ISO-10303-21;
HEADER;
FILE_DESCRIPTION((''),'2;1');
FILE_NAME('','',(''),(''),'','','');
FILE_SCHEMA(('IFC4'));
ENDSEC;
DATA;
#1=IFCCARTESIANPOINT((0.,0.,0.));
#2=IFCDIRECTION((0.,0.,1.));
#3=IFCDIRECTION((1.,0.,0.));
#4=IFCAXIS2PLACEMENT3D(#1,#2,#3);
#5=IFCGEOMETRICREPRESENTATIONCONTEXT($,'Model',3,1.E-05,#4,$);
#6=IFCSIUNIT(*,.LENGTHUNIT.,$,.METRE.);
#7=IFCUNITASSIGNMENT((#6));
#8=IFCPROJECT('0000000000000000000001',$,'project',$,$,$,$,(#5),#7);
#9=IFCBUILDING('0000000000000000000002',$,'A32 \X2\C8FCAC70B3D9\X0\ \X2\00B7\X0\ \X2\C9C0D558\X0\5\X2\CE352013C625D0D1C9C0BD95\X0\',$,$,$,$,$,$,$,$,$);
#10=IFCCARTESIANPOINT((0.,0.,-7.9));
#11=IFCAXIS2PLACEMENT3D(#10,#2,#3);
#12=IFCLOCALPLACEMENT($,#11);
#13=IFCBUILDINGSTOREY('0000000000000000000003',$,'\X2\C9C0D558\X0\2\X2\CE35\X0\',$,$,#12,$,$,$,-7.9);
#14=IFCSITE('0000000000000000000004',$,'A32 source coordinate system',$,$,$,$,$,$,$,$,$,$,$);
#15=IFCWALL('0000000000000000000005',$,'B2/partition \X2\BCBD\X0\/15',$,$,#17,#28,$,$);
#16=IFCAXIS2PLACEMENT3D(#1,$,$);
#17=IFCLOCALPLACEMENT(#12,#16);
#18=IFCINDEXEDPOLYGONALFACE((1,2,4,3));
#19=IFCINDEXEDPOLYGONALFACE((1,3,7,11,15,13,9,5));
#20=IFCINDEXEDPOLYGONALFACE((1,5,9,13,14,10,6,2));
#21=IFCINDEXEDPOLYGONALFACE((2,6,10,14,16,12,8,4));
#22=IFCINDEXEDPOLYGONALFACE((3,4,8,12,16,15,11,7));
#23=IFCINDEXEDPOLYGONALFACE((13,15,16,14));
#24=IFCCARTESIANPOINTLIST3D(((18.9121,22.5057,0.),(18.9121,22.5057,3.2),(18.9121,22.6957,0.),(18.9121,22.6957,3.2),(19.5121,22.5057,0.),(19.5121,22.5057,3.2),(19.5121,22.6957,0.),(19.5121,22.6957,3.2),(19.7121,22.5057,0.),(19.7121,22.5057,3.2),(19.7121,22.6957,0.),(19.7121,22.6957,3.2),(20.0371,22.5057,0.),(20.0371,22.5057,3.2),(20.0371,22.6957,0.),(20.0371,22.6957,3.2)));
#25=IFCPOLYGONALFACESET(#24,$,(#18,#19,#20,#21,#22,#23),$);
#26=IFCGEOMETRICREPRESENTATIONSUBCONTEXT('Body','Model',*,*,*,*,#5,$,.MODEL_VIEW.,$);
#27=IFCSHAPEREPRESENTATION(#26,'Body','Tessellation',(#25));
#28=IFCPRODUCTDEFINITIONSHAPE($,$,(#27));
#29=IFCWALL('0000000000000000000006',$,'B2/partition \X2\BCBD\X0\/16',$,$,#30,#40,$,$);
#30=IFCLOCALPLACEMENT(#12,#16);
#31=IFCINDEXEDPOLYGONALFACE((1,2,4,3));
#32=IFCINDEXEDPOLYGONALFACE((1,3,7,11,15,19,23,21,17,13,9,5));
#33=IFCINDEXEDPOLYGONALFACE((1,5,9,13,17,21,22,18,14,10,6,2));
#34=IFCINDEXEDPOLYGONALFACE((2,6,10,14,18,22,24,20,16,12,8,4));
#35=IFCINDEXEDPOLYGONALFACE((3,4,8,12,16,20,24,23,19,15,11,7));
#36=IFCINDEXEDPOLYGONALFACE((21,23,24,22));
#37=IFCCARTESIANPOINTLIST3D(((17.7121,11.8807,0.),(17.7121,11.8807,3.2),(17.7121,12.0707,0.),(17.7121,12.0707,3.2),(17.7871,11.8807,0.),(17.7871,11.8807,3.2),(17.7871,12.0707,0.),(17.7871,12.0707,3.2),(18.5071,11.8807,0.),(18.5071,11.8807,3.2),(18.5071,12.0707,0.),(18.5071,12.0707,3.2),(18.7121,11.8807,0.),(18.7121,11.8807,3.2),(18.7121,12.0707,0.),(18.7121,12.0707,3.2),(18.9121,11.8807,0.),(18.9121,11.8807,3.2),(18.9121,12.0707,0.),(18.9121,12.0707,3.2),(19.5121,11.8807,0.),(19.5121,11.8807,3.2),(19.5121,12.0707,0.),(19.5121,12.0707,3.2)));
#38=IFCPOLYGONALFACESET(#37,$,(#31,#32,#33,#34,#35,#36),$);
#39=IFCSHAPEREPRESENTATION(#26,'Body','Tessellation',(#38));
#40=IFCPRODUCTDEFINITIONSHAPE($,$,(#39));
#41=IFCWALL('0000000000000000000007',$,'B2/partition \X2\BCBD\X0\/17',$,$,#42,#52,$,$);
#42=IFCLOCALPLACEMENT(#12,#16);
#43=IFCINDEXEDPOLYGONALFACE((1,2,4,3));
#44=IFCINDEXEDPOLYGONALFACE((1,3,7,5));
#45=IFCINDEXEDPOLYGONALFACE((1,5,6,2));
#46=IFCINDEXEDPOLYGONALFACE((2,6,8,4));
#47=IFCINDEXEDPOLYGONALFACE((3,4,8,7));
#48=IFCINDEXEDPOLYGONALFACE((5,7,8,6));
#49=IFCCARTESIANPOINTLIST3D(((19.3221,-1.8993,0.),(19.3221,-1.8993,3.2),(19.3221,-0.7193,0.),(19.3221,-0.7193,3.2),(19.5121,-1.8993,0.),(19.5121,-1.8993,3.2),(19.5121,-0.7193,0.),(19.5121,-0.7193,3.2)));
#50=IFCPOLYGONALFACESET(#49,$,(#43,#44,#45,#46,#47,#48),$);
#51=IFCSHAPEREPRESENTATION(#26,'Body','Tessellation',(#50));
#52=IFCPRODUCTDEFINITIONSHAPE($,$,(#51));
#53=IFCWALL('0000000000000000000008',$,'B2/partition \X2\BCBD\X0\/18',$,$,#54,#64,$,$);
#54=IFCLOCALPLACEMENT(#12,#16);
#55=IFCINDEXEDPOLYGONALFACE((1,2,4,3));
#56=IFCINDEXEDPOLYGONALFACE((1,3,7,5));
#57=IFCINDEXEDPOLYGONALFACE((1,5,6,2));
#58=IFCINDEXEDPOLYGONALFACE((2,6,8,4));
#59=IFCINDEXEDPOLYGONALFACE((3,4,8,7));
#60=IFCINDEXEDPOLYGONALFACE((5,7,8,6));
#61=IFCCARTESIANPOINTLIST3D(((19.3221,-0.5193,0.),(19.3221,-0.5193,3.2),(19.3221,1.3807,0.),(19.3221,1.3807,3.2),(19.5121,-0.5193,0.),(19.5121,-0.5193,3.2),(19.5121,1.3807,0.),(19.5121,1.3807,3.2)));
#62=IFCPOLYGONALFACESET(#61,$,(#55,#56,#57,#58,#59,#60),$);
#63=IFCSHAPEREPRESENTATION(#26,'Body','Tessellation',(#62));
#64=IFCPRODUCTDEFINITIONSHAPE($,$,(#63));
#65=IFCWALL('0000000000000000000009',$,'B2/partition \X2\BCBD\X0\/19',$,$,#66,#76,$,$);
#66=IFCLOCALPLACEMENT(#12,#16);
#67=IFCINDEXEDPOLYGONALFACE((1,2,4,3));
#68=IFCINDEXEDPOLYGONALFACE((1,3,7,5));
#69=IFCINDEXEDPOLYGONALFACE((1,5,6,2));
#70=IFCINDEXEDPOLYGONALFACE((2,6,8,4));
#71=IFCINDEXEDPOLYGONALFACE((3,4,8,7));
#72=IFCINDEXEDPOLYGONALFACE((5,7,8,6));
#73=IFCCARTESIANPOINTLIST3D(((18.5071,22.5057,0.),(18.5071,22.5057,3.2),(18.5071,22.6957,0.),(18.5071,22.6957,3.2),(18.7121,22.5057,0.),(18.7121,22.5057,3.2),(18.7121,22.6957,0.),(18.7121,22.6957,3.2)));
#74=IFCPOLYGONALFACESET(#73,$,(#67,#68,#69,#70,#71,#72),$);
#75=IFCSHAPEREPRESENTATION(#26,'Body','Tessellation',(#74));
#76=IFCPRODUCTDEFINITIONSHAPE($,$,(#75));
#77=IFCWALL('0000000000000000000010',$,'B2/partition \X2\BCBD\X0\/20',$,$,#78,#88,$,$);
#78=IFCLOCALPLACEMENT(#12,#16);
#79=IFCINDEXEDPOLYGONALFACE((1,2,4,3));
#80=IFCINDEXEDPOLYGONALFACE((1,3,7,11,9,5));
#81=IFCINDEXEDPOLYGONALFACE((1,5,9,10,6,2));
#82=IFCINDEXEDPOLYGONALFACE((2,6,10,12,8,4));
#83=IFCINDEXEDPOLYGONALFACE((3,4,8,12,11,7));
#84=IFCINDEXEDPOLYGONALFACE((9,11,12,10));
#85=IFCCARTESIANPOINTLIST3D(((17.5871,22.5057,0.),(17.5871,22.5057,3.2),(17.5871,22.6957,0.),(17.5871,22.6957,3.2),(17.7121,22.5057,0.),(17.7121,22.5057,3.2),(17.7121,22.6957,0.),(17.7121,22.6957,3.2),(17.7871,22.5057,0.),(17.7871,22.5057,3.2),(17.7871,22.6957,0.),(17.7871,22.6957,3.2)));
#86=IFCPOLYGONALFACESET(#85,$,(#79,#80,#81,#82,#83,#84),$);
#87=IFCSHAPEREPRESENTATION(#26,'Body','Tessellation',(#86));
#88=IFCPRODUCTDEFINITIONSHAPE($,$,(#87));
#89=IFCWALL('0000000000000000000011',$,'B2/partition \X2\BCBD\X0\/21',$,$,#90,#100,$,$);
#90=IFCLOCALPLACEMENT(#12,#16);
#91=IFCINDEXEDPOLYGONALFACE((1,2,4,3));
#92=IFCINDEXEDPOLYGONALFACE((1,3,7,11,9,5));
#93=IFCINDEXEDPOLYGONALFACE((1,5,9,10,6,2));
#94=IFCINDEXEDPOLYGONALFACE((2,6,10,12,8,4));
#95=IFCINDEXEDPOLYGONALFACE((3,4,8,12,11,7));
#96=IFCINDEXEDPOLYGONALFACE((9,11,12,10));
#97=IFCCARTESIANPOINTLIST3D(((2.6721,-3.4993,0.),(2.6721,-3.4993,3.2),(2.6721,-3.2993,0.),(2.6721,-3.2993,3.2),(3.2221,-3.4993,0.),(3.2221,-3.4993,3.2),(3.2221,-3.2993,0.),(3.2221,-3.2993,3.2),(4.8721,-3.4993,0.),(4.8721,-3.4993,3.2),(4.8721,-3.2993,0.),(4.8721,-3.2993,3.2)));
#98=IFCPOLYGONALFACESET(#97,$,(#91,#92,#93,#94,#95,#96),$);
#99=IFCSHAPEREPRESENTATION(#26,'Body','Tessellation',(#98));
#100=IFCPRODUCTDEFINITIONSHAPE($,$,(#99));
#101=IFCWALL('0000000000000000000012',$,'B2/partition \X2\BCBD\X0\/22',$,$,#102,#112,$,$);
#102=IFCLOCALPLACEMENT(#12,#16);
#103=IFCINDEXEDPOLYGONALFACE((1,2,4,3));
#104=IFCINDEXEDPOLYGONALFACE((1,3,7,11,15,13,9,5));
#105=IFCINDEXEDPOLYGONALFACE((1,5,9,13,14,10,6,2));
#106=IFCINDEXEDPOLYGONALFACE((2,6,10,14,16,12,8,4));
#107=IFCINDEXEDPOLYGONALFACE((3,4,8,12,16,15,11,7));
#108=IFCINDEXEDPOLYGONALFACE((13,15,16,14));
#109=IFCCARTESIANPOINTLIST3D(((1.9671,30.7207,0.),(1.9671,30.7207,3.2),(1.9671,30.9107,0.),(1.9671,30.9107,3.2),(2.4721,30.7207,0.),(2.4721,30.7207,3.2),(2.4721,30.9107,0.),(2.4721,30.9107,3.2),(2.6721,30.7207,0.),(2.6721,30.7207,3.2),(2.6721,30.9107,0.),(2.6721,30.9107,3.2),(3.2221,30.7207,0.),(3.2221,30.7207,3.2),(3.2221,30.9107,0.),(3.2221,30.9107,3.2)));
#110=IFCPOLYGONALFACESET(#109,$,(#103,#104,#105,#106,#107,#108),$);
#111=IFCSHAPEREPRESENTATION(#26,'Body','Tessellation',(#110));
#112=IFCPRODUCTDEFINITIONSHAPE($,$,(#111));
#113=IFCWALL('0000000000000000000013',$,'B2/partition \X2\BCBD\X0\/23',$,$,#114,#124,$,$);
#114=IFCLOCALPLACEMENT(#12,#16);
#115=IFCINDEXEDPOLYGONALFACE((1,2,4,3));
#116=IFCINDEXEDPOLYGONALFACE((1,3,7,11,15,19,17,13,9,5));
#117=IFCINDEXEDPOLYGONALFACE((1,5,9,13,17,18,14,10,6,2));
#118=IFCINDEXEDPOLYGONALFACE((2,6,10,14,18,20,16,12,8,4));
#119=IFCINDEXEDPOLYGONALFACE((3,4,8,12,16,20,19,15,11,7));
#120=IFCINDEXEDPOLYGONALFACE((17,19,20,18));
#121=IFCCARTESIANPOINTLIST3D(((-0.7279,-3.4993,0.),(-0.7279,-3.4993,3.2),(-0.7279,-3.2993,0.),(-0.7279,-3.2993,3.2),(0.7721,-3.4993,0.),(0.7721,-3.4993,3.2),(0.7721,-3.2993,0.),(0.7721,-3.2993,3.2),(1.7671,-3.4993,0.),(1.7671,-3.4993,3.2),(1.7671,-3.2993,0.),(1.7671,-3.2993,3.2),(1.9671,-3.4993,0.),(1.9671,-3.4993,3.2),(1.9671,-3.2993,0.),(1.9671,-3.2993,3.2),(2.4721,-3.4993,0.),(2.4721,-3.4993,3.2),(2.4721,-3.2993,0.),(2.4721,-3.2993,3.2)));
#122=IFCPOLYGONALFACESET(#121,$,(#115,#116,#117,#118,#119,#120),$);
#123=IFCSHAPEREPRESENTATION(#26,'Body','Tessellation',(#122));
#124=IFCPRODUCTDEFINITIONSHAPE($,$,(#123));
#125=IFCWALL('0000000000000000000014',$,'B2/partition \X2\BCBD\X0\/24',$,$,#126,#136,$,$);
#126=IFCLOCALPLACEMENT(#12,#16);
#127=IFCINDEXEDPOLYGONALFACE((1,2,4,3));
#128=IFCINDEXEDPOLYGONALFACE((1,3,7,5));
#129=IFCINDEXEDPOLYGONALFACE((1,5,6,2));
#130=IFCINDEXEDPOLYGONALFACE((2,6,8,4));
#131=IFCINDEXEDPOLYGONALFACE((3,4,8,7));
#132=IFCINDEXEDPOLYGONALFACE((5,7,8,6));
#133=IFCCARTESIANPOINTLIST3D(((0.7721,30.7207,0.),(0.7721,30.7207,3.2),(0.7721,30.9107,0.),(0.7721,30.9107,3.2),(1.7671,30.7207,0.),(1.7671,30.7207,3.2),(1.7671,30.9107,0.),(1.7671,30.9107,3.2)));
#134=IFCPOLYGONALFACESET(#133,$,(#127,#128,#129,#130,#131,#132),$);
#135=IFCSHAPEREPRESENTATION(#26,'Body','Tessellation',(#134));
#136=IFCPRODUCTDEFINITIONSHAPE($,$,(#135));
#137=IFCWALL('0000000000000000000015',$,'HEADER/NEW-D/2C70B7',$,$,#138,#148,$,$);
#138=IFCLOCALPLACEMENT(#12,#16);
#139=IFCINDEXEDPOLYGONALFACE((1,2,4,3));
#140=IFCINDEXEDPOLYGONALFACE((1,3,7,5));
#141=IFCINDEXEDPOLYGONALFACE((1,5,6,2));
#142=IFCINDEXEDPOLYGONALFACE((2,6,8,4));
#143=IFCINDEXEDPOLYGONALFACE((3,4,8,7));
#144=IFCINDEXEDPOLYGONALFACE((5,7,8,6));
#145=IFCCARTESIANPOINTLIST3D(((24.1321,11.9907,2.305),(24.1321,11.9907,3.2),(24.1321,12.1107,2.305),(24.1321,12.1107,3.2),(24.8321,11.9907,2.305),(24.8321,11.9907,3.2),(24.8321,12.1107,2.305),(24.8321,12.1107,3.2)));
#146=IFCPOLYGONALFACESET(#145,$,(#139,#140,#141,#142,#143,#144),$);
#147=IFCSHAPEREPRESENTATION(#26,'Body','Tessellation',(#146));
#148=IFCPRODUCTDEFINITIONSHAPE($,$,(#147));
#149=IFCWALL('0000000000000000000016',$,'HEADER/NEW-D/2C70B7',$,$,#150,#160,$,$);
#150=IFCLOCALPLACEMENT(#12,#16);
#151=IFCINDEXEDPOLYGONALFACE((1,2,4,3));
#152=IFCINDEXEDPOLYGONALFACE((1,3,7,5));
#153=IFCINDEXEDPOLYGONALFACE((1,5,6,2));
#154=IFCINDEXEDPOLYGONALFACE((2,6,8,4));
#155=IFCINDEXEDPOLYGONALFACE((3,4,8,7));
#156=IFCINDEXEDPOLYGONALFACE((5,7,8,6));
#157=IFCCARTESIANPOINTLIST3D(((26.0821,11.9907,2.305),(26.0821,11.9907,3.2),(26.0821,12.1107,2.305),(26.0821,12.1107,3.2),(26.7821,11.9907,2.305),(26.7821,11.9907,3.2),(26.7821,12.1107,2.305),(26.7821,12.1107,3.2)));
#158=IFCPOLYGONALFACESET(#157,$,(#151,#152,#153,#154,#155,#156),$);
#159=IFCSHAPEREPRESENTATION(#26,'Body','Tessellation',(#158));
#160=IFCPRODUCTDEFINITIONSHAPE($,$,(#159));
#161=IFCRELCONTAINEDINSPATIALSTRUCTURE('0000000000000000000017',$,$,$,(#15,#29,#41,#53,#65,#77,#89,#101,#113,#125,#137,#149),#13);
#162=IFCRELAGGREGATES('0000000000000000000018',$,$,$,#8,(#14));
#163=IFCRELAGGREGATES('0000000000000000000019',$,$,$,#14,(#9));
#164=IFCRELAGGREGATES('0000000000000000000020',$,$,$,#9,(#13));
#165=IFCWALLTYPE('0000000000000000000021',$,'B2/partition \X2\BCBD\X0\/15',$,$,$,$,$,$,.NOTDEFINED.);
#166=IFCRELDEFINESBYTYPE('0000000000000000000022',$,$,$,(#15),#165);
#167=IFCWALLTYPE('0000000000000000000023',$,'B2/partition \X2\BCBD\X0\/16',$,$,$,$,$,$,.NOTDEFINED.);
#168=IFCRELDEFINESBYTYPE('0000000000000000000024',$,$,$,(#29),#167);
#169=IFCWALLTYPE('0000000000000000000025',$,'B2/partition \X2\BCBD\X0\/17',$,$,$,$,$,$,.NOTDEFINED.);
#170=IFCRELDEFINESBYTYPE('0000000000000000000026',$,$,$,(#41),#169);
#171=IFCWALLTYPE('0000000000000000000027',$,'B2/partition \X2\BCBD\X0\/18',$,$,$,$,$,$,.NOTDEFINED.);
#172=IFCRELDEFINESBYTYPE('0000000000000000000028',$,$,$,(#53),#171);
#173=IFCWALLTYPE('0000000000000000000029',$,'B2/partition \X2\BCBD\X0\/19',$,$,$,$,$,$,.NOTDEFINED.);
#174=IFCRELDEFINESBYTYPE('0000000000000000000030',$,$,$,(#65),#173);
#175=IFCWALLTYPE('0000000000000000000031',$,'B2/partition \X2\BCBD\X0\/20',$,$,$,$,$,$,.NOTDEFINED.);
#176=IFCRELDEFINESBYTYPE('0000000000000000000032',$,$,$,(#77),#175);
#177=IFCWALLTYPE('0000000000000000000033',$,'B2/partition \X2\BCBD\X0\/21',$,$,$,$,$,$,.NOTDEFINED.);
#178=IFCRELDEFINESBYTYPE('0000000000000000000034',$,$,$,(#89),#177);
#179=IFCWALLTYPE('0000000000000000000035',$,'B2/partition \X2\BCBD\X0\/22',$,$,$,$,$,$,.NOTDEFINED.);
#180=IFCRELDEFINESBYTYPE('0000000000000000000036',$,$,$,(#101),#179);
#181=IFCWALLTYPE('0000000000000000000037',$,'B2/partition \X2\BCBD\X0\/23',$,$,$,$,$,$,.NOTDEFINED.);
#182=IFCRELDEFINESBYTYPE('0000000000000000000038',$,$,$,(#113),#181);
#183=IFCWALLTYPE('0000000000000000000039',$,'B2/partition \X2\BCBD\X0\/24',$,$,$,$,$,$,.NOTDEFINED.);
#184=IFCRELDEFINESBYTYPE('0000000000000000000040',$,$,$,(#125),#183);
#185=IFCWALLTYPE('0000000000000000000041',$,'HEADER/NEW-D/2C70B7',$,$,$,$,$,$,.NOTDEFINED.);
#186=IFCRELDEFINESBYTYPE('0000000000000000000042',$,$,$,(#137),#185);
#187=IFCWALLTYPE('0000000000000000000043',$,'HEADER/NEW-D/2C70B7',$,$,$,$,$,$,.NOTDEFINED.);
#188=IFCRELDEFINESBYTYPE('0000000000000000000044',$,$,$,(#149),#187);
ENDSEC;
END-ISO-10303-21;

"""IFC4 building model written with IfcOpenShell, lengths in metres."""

from ifc_helpers import new_model, si_unit, frame, origin, origin_with_axes, place, context, subcontext, project, spatial, polyline, outline, extrude, source, transform, mapped, type_object, type_shapes, element, save


model = new_model("IFC4")

# Units and contexts
model_context = context("Model", 3, precision=1e-05, world=origin_with_axes())
body_context = subcontext(model_context, "Body", "Model", "MODEL_VIEW")
ifc_project = project(units=[si_unit("LENGTHUNIT", "METRE")], contexts=[model_context])

# Site, building, storey
site = spatial("IfcSite", under=ifc_project, Name="A32 source coordinate system")
building = spatial("IfcBuilding", under=site, Name="A32 주거동 · 지하5층–옥탑지붕")
storey_placement = place(None, frame((0.0, 0.0, -7.9), z_axis=(0.0, 0.0, 1.0), x_axis=(1.0, 0.0, 0.0)))
storey = spatial("IfcBuildingStorey", under=building, at=storey_placement, Name="지하2층", Elevation=-7.9)

# Walls
wall_type_1 = type_object("IfcWallType", Name="B2/partition 벽/15", PredefinedType="NOTDEFINED")
shared_shape_1 = source(origin(), body_context, "Body", "SweptSolid", [
    extrude(outline(polyline([(19.7121, 22.5057), (19.5121, 22.5057), (18.9121, 22.5057), (18.9121, 22.6957), (19.5121, 22.6957), (19.7121, 22.6957), (20.0371, 22.6957), (20.0371, 22.5057), (19.7121, 22.5057)])), origin(), (0.0, 0.0, 1.0), 3.2),
])
type_shapes(wall_type_1, [shared_shape_1])
wall_1_placement = place(storey_placement, origin_with_axes())
element("IfcWall", 1, at=wall_1_placement, inside=storey, type_object=wall_type_1, Name="B2/partition 벽/15", context=body_context, shape_type="MappedRepresentation", body=[
    mapped(shared_shape_1, transform((0.0, 0.0, 0.0), scale=1.0)),
])
wall_type_2 = type_object("IfcWallType", Name="B2/partition 벽/16", PredefinedType="NOTDEFINED")
shared_shape_2 = source(origin(), body_context, "Body", "SweptSolid", [
    extrude(outline(polyline([(18.9121, 12.0707), (19.5121, 12.0707), (19.5121, 11.8807), (18.9121, 11.8807), (18.7121, 11.8807), (18.5071, 11.8807), (17.7871, 11.8807), (17.7121, 11.8807), (17.7121, 12.0707), (17.7871, 12.0707), (18.5071, 12.0707), (18.7121, 12.0707), (18.9121, 12.0707)])), origin(), (0.0, 0.0, 1.0), 3.2),
])
type_shapes(wall_type_2, [shared_shape_2])
wall_2_placement = place(storey_placement, origin_with_axes())
element("IfcWall", 2, at=wall_2_placement, inside=storey, type_object=wall_type_2, Name="B2/partition 벽/16", context=body_context, shape_type="MappedRepresentation", body=[
    mapped(shared_shape_2, transform((0.0, 0.0, 0.0), scale=1.0)),
])
wall_type_3 = type_object("IfcWallType", Name="B2/partition 벽/17", PredefinedType="NOTDEFINED")
shared_shape_3 = source(origin(), body_context, "Body", "SweptSolid", [
    extrude(outline(polyline([(19.5121, -0.7193), (19.5121, -1.8993), (19.3221, -1.8993), (19.3221, -0.7193), (19.5121, -0.7193)])), origin(), (0.0, 0.0, 1.0), 3.2),
])
type_shapes(wall_type_3, [shared_shape_3])
wall_3_placement = place(storey_placement, origin_with_axes())
element("IfcWall", 3, at=wall_3_placement, inside=storey, type_object=wall_type_3, Name="B2/partition 벽/17", context=body_context, shape_type="MappedRepresentation", body=[
    mapped(shared_shape_3, transform((0.0, 0.0, 0.0), scale=1.0)),
])
wall_type_4 = type_object("IfcWallType", Name="B2/partition 벽/18", PredefinedType="NOTDEFINED")
shared_shape_4 = source(origin(), body_context, "Body", "SweptSolid", [
    extrude(outline(polyline([(19.3221, 1.3807), (19.5121, 1.3807), (19.5121, -0.5193), (19.3221, -0.5193), (19.3221, 1.3807)])), origin(), (0.0, 0.0, 1.0), 3.2),
])
type_shapes(wall_type_4, [shared_shape_4])
wall_4_placement = place(storey_placement, origin_with_axes())
element("IfcWall", 4, at=wall_4_placement, inside=storey, type_object=wall_type_4, Name="B2/partition 벽/18", context=body_context, shape_type="MappedRepresentation", body=[
    mapped(shared_shape_4, transform((0.0, 0.0, 0.0), scale=1.0)),
])
wall_type_5 = type_object("IfcWallType", Name="B2/partition 벽/19", PredefinedType="NOTDEFINED")
shared_shape_5 = source(origin(), body_context, "Body", "SweptSolid", [
    extrude(outline(polyline([(18.5071, 22.6957), (18.7121, 22.6957), (18.7121, 22.5057), (18.5071, 22.5057), (18.5071, 22.6957)])), origin(), (0.0, 0.0, 1.0), 3.2),
])
type_shapes(wall_type_5, [shared_shape_5])
wall_5_placement = place(storey_placement, origin_with_axes())
element("IfcWall", 5, at=wall_5_placement, inside=storey, type_object=wall_type_5, Name="B2/partition 벽/19", context=body_context, shape_type="MappedRepresentation", body=[
    mapped(shared_shape_5, transform((0.0, 0.0, 0.0), scale=1.0)),
])
wall_type_6 = type_object("IfcWallType", Name="B2/partition 벽/20", PredefinedType="NOTDEFINED")
shared_shape_6 = source(origin(), body_context, "Body", "SweptSolid", [
    extrude(outline(polyline([(17.5871, 22.5057), (17.5871, 22.6957), (17.7121, 22.6957), (17.7871, 22.6957), (17.7871, 22.5057), (17.7121, 22.5057), (17.5871, 22.5057)])), origin(), (0.0, 0.0, 1.0), 3.2),
])
type_shapes(wall_type_6, [shared_shape_6])
wall_6_placement = place(storey_placement, origin_with_axes())
element("IfcWall", 6, at=wall_6_placement, inside=storey, type_object=wall_type_6, Name="B2/partition 벽/20", context=body_context, shape_type="MappedRepresentation", body=[
    mapped(shared_shape_6, transform((0.0, 0.0, 0.0), scale=1.0)),
])
wall_type_7 = type_object("IfcWallType", Name="B2/partition 벽/21", PredefinedType="NOTDEFINED")
shared_shape_7 = source(origin(), body_context, "Body", "SweptSolid", [
    extrude(outline(polyline([(2.6721, -3.4993), (2.6721, -3.2993), (3.2221, -3.2993), (4.8721, -3.2993), (4.8721, -3.4993), (3.2221, -3.4993), (2.6721, -3.4993)])), origin(), (0.0, 0.0, 1.0), 3.2),
])
type_shapes(wall_type_7, [shared_shape_7])
wall_7_placement = place(storey_placement, origin_with_axes())
element("IfcWall", 7, at=wall_7_placement, inside=storey, type_object=wall_type_7, Name="B2/partition 벽/21", context=body_context, shape_type="MappedRepresentation", body=[
    mapped(shared_shape_7, transform((0.0, 0.0, 0.0), scale=1.0)),
])
wall_type_8 = type_object("IfcWallType", Name="B2/partition 벽/22", PredefinedType="NOTDEFINED")
shared_shape_8 = source(origin(), body_context, "Body", "SweptSolid", [
    extrude(outline(polyline([(2.6721, 30.7207), (2.4721, 30.7207), (1.9671, 30.7207), (1.9671, 30.9107), (2.4721, 30.9107), (2.6721, 30.9107), (3.2221, 30.9107), (3.2221, 30.7207), (2.6721, 30.7207)])), origin(), (0.0, 0.0, 1.0), 3.2),
])
type_shapes(wall_type_8, [shared_shape_8])
wall_8_placement = place(storey_placement, origin_with_axes())
element("IfcWall", 8, at=wall_8_placement, inside=storey, type_object=wall_type_8, Name="B2/partition 벽/22", context=body_context, shape_type="MappedRepresentation", body=[
    mapped(shared_shape_8, transform((0.0, 0.0, 0.0), scale=1.0)),
])
wall_type_9 = type_object("IfcWallType", Name="B2/partition 벽/23", PredefinedType="NOTDEFINED")
shared_shape_9 = source(origin(), body_context, "Body", "SweptSolid", [
    extrude(outline(polyline([(2.4721, -3.2993), (2.4721, -3.4993), (1.9671, -3.4993), (1.7671, -3.4993), (0.7721, -3.4993), (-0.7279, -3.4993), (-0.7279, -3.2993), (0.7721, -3.2993), (1.7671, -3.2993), (1.9671, -3.2993), (2.4721, -3.2993)])), origin(), (0.0, 0.0, 1.0), 3.2),
])
type_shapes(wall_type_9, [shared_shape_9])
wall_9_placement = place(storey_placement, origin_with_axes())
element("IfcWall", 9, at=wall_9_placement, inside=storey, type_object=wall_type_9, Name="B2/partition 벽/23", context=body_context, shape_type="MappedRepresentation", body=[
    mapped(shared_shape_9, transform((0.0, 0.0, 0.0), scale=1.0)),
])
wall_type_10 = type_object("IfcWallType", Name="B2/partition 벽/24", PredefinedType="NOTDEFINED")
shared_shape_10 = source(origin(), body_context, "Body", "SweptSolid", [
    extrude(outline(polyline([(1.7671, 30.9107), (1.7671, 30.7207), (0.7721, 30.7207), (0.7721, 30.9107), (1.7671, 30.9107)])), origin(), (0.0, 0.0, 1.0), 3.2),
])
type_shapes(wall_type_10, [shared_shape_10])
wall_10_placement = place(storey_placement, origin_with_axes())
element("IfcWall", 10, at=wall_10_placement, inside=storey, type_object=wall_type_10, Name="B2/partition 벽/24", context=body_context, shape_type="MappedRepresentation", body=[
    mapped(shared_shape_10, transform((0.0, 0.0, 0.0), scale=1.0)),
])
wall_type_11 = type_object("IfcWallType", Name="HEADER/NEW-D/2C70B7", PredefinedType="NOTDEFINED")
shared_shape_11 = source(origin(), body_context, "Body", "SweptSolid", [
    extrude(outline(polyline([(24.1321, 11.9907), (24.1321, 12.1107), (24.8321, 12.1107), (24.8321, 11.9907), (24.1321, 11.9907)])), frame((0.0, 0.0, 2.305)), (0.0, 0.0, 1.0), 0.895),
])
type_shapes(wall_type_11, [shared_shape_11])
wall_11_placement = place(storey_placement, origin_with_axes())
element("IfcWall", 11, at=wall_11_placement, inside=storey, type_object=wall_type_11, Name="HEADER/NEW-D/2C70B7", context=body_context, shape_type="MappedRepresentation", body=[
    mapped(shared_shape_11, transform((0.0, 0.0, 0.0), scale=1.0)),
])
wall_type_12 = type_object("IfcWallType", Name="HEADER/NEW-D/2C70B7", PredefinedType="NOTDEFINED")
shared_shape_12 = source(origin(), body_context, "Body", "SweptSolid", [
    extrude(outline(polyline([(26.0821, 11.9907), (26.0821, 12.1107), (26.7821, 12.1107), (26.7821, 11.9907), (26.0821, 11.9907)])), frame((0.0, 0.0, 2.305)), (0.0, 0.0, 1.0), 0.895),
])
type_shapes(wall_type_12, [shared_shape_12])
wall_12_placement = place(storey_placement, origin_with_axes())
element("IfcWall", 12, at=wall_12_placement, inside=storey, type_object=wall_type_12, Name="HEADER/NEW-D/2C70B7", context=body_context, shape_type="MappedRepresentation", body=[
    mapped(shared_shape_12, transform((0.0, 0.0, 0.0), scale=1.0)),
])

save(model, "model.ifc")
